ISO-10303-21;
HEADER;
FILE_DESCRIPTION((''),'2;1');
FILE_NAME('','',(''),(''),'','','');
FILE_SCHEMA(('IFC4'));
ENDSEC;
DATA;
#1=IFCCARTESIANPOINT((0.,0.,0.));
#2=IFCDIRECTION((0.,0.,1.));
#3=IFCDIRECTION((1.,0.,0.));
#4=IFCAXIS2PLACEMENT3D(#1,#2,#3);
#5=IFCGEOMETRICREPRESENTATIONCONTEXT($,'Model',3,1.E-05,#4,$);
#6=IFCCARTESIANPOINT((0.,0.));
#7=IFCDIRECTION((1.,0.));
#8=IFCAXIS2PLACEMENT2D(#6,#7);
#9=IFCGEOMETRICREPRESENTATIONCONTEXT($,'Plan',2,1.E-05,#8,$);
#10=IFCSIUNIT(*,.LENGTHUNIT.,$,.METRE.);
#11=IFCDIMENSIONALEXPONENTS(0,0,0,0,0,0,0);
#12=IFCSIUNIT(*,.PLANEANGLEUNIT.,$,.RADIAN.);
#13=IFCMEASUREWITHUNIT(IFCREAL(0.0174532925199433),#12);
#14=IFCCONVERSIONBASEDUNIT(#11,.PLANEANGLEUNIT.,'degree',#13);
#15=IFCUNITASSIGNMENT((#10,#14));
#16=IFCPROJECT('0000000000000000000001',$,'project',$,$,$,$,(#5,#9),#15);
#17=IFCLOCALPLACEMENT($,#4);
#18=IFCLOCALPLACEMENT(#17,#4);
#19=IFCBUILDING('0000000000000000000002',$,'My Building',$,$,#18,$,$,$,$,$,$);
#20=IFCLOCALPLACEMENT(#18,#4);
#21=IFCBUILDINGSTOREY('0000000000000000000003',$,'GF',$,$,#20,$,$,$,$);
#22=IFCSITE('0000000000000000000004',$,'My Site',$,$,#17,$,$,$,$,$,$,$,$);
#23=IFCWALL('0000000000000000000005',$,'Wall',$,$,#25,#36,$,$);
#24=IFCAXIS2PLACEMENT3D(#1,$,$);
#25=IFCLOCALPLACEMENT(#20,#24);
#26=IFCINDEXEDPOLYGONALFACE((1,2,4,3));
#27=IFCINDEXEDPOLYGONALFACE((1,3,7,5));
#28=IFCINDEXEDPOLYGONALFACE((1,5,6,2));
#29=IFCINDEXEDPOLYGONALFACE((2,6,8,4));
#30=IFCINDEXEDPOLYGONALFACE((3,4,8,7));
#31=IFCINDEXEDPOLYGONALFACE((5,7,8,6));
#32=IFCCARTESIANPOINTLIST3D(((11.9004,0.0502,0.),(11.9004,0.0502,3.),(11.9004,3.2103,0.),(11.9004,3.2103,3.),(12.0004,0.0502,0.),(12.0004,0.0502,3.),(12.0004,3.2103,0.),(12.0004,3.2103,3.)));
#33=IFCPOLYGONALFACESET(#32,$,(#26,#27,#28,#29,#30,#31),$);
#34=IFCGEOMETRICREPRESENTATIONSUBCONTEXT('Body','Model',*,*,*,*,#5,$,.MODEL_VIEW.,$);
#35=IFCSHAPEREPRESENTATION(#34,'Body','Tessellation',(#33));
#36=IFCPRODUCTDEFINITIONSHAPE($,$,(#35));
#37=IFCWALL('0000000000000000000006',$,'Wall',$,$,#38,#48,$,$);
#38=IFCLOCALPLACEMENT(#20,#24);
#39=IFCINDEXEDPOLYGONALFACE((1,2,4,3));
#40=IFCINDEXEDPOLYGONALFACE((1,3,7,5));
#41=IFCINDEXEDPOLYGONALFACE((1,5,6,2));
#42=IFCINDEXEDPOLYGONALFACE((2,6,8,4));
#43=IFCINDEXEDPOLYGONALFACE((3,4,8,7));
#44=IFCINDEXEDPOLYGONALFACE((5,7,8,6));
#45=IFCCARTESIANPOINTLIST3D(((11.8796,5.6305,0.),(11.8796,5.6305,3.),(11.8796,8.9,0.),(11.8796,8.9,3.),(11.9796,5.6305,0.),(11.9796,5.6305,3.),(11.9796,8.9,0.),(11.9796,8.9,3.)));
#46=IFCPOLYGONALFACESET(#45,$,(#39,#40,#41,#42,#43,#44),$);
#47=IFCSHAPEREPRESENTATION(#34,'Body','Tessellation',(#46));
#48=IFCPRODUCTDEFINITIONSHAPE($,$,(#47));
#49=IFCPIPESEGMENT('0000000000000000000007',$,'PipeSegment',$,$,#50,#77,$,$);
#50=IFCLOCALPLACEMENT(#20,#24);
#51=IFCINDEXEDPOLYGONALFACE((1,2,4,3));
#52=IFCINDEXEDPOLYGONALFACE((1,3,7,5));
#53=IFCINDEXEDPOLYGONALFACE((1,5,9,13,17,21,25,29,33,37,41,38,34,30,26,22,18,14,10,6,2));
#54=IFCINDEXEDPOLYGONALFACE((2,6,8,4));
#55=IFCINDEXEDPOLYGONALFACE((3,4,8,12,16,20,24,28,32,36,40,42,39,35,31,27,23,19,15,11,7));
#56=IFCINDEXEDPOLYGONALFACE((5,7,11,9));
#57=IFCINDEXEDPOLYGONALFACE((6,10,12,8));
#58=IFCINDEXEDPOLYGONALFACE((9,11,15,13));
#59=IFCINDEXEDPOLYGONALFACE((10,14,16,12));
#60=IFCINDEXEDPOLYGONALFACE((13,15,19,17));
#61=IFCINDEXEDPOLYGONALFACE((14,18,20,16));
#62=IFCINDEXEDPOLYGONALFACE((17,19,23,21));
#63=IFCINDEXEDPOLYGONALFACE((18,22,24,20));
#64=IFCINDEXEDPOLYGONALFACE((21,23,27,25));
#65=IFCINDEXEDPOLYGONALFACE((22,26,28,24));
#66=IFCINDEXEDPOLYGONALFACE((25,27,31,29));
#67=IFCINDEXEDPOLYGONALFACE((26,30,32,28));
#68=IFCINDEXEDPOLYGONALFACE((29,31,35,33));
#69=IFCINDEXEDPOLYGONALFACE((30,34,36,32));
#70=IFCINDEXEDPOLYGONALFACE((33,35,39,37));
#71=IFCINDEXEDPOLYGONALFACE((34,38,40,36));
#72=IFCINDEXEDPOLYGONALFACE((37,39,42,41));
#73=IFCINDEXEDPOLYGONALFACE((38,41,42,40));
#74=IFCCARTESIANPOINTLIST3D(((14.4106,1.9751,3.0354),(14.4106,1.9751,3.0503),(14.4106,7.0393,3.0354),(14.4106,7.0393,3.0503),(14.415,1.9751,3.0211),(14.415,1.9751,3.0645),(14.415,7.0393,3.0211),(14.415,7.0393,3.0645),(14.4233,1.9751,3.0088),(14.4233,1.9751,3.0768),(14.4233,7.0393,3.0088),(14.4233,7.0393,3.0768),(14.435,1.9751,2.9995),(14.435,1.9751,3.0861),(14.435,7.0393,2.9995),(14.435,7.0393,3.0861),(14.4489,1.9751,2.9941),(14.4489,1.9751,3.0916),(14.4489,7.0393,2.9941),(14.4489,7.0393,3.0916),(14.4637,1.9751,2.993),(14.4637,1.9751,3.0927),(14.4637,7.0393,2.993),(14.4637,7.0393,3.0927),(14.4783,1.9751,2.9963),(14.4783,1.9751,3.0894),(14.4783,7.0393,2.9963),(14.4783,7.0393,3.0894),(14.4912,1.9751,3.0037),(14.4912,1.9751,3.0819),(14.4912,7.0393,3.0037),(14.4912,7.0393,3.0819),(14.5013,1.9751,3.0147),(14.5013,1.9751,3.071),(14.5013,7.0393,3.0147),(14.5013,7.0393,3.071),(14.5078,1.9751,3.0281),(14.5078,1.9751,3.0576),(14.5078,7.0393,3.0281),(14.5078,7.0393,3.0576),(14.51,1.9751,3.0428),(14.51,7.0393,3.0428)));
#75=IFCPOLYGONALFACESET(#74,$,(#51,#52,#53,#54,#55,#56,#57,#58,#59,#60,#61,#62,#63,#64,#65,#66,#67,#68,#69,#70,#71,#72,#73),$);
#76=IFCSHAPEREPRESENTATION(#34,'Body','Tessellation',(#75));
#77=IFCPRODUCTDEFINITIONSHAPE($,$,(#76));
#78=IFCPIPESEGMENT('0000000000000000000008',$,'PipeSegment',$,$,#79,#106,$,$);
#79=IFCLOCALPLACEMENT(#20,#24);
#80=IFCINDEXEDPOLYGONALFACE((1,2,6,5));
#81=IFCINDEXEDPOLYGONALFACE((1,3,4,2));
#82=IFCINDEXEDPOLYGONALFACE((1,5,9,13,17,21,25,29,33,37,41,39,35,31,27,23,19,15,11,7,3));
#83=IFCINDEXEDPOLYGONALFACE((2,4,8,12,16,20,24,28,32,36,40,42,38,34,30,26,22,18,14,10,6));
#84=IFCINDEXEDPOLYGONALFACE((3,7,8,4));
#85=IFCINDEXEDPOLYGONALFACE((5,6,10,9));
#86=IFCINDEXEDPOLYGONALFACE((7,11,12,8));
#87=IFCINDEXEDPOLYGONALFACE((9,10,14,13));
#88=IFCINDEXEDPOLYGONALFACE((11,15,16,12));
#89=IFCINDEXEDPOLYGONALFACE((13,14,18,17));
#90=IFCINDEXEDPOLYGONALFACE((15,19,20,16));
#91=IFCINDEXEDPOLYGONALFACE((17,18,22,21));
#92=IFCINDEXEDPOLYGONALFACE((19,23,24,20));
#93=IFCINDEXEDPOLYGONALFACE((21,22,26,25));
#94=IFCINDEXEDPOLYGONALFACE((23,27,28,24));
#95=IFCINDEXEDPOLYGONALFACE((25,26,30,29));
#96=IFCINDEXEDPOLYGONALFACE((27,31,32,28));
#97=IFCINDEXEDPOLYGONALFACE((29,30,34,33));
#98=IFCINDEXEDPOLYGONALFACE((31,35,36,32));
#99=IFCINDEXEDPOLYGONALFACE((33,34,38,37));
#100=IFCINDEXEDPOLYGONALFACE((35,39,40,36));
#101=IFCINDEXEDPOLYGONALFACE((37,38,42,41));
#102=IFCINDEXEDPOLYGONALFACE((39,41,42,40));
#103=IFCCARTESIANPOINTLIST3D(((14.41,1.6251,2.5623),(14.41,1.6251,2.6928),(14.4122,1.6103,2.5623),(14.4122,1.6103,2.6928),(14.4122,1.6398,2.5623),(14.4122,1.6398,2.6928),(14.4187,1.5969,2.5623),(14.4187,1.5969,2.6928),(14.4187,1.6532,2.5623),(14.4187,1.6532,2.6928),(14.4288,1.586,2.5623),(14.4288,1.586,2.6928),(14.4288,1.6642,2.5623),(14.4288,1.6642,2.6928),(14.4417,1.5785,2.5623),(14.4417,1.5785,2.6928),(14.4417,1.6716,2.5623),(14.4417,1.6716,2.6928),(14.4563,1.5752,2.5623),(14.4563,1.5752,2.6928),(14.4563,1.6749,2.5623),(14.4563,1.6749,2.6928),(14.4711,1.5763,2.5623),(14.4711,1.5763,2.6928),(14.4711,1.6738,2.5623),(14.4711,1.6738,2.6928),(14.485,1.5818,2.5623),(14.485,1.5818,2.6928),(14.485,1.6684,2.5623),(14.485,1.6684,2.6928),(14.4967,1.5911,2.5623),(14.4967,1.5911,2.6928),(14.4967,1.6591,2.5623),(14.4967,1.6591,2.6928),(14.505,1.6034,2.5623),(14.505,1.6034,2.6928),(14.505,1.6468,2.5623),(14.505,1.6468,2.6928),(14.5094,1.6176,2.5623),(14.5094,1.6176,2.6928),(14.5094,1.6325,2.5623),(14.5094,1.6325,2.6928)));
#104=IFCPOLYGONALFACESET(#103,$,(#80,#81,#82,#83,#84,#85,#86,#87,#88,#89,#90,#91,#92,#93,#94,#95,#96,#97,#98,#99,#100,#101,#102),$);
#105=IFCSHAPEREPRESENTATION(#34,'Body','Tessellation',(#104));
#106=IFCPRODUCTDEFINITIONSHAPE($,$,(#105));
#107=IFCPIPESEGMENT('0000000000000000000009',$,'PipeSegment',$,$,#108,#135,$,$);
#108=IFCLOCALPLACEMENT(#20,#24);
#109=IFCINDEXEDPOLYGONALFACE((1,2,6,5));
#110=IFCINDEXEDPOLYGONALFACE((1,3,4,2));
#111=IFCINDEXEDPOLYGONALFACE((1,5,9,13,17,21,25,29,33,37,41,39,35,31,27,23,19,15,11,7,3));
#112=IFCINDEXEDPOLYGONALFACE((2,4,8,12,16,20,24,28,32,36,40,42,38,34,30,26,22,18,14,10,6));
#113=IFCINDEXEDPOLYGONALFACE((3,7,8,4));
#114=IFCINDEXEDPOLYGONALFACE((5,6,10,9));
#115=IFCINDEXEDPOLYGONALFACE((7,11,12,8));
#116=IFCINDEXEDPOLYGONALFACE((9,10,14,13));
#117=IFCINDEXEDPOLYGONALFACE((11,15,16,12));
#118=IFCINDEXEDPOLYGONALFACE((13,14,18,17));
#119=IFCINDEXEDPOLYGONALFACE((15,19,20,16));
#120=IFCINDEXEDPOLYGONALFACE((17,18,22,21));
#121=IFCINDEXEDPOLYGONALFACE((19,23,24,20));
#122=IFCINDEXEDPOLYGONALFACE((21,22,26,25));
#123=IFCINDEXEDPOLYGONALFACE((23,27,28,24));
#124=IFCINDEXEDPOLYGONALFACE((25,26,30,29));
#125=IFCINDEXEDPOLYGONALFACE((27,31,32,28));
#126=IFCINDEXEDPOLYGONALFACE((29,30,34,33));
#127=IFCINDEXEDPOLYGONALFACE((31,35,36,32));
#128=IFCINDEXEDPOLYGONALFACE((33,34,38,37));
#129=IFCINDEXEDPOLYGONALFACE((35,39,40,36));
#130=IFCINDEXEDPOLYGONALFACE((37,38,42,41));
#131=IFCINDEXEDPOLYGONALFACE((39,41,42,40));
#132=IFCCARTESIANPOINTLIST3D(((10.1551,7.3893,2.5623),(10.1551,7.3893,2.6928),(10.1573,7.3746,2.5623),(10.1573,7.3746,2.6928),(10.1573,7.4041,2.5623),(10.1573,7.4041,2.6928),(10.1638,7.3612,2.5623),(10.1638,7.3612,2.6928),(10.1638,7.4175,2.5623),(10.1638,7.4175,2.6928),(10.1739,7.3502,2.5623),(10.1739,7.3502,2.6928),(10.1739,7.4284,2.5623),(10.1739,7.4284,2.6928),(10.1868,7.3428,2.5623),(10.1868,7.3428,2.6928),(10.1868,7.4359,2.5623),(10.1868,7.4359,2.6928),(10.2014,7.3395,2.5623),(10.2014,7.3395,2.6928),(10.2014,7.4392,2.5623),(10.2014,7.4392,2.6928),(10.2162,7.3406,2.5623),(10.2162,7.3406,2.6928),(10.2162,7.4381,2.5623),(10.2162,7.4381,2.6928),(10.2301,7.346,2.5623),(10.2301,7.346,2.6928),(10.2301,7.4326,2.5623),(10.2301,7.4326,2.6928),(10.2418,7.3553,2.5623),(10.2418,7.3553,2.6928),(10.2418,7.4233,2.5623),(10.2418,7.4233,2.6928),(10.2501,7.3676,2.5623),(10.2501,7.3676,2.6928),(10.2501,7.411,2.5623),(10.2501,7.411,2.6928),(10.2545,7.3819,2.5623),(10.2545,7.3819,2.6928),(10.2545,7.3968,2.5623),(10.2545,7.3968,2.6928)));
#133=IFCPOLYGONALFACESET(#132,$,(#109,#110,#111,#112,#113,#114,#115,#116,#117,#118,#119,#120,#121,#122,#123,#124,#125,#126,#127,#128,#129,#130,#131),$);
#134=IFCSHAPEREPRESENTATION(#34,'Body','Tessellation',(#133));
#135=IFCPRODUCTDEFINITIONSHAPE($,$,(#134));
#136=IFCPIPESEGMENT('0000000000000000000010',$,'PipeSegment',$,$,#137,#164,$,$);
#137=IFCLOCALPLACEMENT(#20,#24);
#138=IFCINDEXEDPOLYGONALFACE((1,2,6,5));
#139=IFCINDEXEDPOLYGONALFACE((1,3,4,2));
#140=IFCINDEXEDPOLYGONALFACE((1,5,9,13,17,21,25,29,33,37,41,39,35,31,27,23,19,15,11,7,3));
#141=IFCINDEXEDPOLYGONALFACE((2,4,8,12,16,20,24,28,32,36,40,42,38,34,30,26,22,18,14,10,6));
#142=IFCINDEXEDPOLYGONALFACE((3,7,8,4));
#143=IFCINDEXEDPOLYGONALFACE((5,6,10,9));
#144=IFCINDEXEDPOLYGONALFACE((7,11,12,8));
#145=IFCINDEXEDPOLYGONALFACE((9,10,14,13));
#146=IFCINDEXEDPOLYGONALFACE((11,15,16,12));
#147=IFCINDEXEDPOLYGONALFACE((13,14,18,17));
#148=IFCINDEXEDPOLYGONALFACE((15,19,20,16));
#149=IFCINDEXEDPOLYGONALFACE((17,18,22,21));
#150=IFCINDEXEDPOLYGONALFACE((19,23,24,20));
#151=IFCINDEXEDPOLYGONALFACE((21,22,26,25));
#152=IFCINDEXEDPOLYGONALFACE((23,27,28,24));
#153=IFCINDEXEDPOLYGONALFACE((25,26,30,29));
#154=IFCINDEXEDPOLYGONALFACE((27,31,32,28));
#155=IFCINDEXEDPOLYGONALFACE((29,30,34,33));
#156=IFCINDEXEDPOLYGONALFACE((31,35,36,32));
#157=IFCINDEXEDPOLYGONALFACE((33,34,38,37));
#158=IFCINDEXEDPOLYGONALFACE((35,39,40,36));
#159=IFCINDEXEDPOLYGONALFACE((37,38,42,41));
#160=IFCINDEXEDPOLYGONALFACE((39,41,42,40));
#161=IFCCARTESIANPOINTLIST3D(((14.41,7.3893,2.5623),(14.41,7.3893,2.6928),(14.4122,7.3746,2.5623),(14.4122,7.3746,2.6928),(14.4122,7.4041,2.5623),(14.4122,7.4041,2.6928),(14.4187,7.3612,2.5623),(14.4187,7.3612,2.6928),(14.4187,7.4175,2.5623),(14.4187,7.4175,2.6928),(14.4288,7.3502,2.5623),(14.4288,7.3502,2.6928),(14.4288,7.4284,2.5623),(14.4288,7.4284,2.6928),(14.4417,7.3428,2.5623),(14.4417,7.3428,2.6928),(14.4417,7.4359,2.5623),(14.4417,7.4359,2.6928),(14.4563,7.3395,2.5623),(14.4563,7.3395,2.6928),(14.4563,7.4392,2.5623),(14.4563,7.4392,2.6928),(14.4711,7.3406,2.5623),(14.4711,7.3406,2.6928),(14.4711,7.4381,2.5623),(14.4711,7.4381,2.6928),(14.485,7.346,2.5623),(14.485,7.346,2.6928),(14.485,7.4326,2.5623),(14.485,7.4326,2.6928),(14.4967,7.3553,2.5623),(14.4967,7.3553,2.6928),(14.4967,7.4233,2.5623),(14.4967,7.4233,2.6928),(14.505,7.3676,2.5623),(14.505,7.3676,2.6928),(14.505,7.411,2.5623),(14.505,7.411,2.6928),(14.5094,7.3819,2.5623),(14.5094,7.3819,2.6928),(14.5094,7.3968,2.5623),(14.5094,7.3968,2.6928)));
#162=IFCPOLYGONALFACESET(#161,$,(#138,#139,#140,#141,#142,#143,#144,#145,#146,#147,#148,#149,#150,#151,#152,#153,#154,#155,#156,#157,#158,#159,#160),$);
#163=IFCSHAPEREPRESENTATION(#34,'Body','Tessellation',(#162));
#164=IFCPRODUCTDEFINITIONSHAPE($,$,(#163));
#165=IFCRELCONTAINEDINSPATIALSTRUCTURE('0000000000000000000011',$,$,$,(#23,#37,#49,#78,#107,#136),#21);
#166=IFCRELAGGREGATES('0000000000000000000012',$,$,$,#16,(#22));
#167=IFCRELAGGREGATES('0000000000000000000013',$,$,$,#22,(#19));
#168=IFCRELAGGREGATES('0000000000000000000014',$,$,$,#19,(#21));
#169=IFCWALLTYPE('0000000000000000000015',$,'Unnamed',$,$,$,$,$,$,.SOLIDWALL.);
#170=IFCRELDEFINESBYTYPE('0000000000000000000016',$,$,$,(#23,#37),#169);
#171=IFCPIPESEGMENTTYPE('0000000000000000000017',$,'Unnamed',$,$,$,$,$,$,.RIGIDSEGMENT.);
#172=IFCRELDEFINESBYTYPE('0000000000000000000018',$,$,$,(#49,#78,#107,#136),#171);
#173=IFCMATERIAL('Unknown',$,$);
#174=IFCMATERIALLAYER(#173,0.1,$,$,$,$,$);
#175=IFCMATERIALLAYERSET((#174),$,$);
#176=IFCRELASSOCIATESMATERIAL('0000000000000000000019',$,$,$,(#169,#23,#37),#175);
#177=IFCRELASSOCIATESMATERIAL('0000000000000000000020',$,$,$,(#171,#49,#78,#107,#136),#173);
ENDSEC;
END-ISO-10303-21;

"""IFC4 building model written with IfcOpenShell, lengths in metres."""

from ifc_helpers import new_model, entity, si_unit, converted_unit, frame, origin_with_axes, origin_2d_with_axis, place, context, subcontext, project, spatial, line, indexed_curve, circle, outline, extrude, material, layer, layer_set, layer_usage, material_profile, profile_set, profile_usage, type_object, element, save


model = new_model("IFC4")

# Units and contexts
model_context = context("Model", 3, precision=1e-05, world=origin_with_axes())
plan_context = context("Plan", 2, precision=1e-05, world=origin_2d_with_axis())
body_context = subcontext(model_context, "Body", "Model", "MODEL_VIEW")
ifc_project = project(units=[si_unit("LENGTHUNIT", "METRE"), converted_unit("PLANEANGLEUNIT", "degree", entity("IfcReal", 0.0174532925199433), si_unit("PLANEANGLEUNIT", "RADIAN"), dimensions=[0, 0, 0, 0, 0, 0, 0])], contexts=[model_context, plan_context])

# Site, building, storey
site_placement = place(None, origin_with_axes())
site = spatial("IfcSite", under=ifc_project, at=site_placement, Name="My Site")
building_placement = place(site_placement, origin_with_axes())
building = spatial("IfcBuilding", under=site, at=building_placement, Name="My Building")
storey_placement = place(building_placement, origin_with_axes())
storey = spatial("IfcBuildingStorey", under=building, at=storey_placement, Name="GF")

# Walls
ifc_material = material(Name="Unknown")
ifc_layer = layer(ifc_material, 0.1)
ifc_layer_set = layer_set([ifc_layer])
ifc_layer_usage_1 = layer_usage(ifc_layer_set, "AXIS2", "POSITIVE", 0.0)
wall_type = type_object("IfcWallType", Name="Unnamed", PredefinedType="SOLIDWALL", material=ifc_layer_set)
wall_1_placement = place(storey_placement, frame((12.0004, 0.0502, 0.0), z_axis=(0.0, 0.0, 1.0), x_axis=(0.000013, 1.0, 0.0)))
element("IfcWall", 1, at=wall_1_placement, inside=storey, type_object=wall_type, material=ifc_layer_usage_1, Name="Wall", context=body_context, shape_type="SweptSolid", body=[
    extrude(outline(indexed_curve([(0.0, 0.0), (0.0, 0.1), (3.1602, 0.1), (3.1602, 0.0)], segments=[line(1, 2, 3, 4, 1)])), origin_with_axes(), (0.0, 0.0, 1.0), 3.0),
])
ifc_layer_usage_2 = layer_usage(ifc_layer_set, "AXIS2", "POSITIVE", 0.0)
wall_2_placement = place(storey_placement, frame((11.9796, 5.6305, 0.0), z_axis=(0.0, 0.0, 1.0), x_axis=(0.0, 1.0, 0.0)))
element("IfcWall", 2, at=wall_2_placement, inside=storey, type_object=wall_type, material=ifc_layer_usage_2, Name="Wall", context=body_context, shape_type="SweptSolid", body=[
    extrude(outline(indexed_curve([(0.0, 0.0), (0.0, 0.1), (3.2695, 0.1), (3.2695, 0.0)], segments=[line(1, 2, 3, 4, 1)])), origin_with_axes(), (0.0, 0.0, 1.0), 3.0),
])

# Pipe segments
ifc_material_profile = material_profile(ifc_material, circle(Radius=0.05))
ifc_profile_set = profile_set([ifc_material_profile])
ifc_profile_usage_1 = profile_usage(ifc_profile_set, cardinal=5)
pipe_segment_type = type_object("IfcPipeSegmentType", Name="Unnamed", PredefinedType="RIGIDSEGMENT", material=ifc_profile_set)
pipe_segment_1_placement = place(storey_placement, frame((14.46, 7.0393, 3.0428), z_axis=(0.0, -1.0, 0.0), x_axis=(1.0, 0.0, 0.0)))
element("IfcPipeSegment", 3, at=pipe_segment_1_placement, inside=storey, type_object=pipe_segment_type, material=ifc_profile_usage_1, Name="PipeSegment", context=body_context, shape_type="SweptSolid", body=[
    extrude(circle(Radius=0.05), origin_with_axes(), (0.0, 0.0, 1.0), 5.0643),
])
ifc_profile_usage_2 = profile_usage(ifc_profile_set, cardinal=5)
pipe_segment_2_placement = place(storey_placement, frame((14.46, 1.6251, 2.6928), z_axis=(0.0, 0.0, -1.0), x_axis=(-1.0, 0.0, 0.0)))
element("IfcPipeSegment", 4, at=pipe_segment_2_placement, inside=storey, type_object=pipe_segment_type, material=ifc_profile_usage_2, Name="PipeSegment", context=body_context, shape_type="SweptSolid", body=[
    extrude(circle(Radius=0.05), origin_with_axes(), (0.0, 0.0, 1.0), 0.1306),
])
ifc_profile_usage_3 = profile_usage(ifc_profile_set, cardinal=5)
pipe_segment_3_placement = place(storey_placement, frame((10.2051, 7.3893, 2.6928), z_axis=(0.0, 0.0, -1.0), x_axis=(-1.0, 0.0, 0.0)))
element("IfcPipeSegment", 5, at=pipe_segment_3_placement, inside=storey, type_object=pipe_segment_type, material=ifc_profile_usage_3, Name="PipeSegment", context=body_context, shape_type="SweptSolid", body=[
    extrude(circle(Radius=0.05), origin_with_axes(), (0.0, 0.0, 1.0), 0.1306),
])
ifc_profile_usage_4 = profile_usage(ifc_profile_set, cardinal=5)
pipe_segment_4_placement = place(storey_placement, frame((14.46, 7.3893, 2.6928), z_axis=(0.0, 0.0, -1.0), x_axis=(-1.0, 0.0, 0.0)))
element("IfcPipeSegment", 6, at=pipe_segment_4_placement, inside=storey, type_object=pipe_segment_type, material=ifc_profile_usage_4, Name="PipeSegment", context=body_context, shape_type="SweptSolid", body=[
    extrude(circle(Radius=0.05), origin_with_axes(), (0.0, 0.0, 1.0), 0.1306),
])

save(model, "model.ifc")
